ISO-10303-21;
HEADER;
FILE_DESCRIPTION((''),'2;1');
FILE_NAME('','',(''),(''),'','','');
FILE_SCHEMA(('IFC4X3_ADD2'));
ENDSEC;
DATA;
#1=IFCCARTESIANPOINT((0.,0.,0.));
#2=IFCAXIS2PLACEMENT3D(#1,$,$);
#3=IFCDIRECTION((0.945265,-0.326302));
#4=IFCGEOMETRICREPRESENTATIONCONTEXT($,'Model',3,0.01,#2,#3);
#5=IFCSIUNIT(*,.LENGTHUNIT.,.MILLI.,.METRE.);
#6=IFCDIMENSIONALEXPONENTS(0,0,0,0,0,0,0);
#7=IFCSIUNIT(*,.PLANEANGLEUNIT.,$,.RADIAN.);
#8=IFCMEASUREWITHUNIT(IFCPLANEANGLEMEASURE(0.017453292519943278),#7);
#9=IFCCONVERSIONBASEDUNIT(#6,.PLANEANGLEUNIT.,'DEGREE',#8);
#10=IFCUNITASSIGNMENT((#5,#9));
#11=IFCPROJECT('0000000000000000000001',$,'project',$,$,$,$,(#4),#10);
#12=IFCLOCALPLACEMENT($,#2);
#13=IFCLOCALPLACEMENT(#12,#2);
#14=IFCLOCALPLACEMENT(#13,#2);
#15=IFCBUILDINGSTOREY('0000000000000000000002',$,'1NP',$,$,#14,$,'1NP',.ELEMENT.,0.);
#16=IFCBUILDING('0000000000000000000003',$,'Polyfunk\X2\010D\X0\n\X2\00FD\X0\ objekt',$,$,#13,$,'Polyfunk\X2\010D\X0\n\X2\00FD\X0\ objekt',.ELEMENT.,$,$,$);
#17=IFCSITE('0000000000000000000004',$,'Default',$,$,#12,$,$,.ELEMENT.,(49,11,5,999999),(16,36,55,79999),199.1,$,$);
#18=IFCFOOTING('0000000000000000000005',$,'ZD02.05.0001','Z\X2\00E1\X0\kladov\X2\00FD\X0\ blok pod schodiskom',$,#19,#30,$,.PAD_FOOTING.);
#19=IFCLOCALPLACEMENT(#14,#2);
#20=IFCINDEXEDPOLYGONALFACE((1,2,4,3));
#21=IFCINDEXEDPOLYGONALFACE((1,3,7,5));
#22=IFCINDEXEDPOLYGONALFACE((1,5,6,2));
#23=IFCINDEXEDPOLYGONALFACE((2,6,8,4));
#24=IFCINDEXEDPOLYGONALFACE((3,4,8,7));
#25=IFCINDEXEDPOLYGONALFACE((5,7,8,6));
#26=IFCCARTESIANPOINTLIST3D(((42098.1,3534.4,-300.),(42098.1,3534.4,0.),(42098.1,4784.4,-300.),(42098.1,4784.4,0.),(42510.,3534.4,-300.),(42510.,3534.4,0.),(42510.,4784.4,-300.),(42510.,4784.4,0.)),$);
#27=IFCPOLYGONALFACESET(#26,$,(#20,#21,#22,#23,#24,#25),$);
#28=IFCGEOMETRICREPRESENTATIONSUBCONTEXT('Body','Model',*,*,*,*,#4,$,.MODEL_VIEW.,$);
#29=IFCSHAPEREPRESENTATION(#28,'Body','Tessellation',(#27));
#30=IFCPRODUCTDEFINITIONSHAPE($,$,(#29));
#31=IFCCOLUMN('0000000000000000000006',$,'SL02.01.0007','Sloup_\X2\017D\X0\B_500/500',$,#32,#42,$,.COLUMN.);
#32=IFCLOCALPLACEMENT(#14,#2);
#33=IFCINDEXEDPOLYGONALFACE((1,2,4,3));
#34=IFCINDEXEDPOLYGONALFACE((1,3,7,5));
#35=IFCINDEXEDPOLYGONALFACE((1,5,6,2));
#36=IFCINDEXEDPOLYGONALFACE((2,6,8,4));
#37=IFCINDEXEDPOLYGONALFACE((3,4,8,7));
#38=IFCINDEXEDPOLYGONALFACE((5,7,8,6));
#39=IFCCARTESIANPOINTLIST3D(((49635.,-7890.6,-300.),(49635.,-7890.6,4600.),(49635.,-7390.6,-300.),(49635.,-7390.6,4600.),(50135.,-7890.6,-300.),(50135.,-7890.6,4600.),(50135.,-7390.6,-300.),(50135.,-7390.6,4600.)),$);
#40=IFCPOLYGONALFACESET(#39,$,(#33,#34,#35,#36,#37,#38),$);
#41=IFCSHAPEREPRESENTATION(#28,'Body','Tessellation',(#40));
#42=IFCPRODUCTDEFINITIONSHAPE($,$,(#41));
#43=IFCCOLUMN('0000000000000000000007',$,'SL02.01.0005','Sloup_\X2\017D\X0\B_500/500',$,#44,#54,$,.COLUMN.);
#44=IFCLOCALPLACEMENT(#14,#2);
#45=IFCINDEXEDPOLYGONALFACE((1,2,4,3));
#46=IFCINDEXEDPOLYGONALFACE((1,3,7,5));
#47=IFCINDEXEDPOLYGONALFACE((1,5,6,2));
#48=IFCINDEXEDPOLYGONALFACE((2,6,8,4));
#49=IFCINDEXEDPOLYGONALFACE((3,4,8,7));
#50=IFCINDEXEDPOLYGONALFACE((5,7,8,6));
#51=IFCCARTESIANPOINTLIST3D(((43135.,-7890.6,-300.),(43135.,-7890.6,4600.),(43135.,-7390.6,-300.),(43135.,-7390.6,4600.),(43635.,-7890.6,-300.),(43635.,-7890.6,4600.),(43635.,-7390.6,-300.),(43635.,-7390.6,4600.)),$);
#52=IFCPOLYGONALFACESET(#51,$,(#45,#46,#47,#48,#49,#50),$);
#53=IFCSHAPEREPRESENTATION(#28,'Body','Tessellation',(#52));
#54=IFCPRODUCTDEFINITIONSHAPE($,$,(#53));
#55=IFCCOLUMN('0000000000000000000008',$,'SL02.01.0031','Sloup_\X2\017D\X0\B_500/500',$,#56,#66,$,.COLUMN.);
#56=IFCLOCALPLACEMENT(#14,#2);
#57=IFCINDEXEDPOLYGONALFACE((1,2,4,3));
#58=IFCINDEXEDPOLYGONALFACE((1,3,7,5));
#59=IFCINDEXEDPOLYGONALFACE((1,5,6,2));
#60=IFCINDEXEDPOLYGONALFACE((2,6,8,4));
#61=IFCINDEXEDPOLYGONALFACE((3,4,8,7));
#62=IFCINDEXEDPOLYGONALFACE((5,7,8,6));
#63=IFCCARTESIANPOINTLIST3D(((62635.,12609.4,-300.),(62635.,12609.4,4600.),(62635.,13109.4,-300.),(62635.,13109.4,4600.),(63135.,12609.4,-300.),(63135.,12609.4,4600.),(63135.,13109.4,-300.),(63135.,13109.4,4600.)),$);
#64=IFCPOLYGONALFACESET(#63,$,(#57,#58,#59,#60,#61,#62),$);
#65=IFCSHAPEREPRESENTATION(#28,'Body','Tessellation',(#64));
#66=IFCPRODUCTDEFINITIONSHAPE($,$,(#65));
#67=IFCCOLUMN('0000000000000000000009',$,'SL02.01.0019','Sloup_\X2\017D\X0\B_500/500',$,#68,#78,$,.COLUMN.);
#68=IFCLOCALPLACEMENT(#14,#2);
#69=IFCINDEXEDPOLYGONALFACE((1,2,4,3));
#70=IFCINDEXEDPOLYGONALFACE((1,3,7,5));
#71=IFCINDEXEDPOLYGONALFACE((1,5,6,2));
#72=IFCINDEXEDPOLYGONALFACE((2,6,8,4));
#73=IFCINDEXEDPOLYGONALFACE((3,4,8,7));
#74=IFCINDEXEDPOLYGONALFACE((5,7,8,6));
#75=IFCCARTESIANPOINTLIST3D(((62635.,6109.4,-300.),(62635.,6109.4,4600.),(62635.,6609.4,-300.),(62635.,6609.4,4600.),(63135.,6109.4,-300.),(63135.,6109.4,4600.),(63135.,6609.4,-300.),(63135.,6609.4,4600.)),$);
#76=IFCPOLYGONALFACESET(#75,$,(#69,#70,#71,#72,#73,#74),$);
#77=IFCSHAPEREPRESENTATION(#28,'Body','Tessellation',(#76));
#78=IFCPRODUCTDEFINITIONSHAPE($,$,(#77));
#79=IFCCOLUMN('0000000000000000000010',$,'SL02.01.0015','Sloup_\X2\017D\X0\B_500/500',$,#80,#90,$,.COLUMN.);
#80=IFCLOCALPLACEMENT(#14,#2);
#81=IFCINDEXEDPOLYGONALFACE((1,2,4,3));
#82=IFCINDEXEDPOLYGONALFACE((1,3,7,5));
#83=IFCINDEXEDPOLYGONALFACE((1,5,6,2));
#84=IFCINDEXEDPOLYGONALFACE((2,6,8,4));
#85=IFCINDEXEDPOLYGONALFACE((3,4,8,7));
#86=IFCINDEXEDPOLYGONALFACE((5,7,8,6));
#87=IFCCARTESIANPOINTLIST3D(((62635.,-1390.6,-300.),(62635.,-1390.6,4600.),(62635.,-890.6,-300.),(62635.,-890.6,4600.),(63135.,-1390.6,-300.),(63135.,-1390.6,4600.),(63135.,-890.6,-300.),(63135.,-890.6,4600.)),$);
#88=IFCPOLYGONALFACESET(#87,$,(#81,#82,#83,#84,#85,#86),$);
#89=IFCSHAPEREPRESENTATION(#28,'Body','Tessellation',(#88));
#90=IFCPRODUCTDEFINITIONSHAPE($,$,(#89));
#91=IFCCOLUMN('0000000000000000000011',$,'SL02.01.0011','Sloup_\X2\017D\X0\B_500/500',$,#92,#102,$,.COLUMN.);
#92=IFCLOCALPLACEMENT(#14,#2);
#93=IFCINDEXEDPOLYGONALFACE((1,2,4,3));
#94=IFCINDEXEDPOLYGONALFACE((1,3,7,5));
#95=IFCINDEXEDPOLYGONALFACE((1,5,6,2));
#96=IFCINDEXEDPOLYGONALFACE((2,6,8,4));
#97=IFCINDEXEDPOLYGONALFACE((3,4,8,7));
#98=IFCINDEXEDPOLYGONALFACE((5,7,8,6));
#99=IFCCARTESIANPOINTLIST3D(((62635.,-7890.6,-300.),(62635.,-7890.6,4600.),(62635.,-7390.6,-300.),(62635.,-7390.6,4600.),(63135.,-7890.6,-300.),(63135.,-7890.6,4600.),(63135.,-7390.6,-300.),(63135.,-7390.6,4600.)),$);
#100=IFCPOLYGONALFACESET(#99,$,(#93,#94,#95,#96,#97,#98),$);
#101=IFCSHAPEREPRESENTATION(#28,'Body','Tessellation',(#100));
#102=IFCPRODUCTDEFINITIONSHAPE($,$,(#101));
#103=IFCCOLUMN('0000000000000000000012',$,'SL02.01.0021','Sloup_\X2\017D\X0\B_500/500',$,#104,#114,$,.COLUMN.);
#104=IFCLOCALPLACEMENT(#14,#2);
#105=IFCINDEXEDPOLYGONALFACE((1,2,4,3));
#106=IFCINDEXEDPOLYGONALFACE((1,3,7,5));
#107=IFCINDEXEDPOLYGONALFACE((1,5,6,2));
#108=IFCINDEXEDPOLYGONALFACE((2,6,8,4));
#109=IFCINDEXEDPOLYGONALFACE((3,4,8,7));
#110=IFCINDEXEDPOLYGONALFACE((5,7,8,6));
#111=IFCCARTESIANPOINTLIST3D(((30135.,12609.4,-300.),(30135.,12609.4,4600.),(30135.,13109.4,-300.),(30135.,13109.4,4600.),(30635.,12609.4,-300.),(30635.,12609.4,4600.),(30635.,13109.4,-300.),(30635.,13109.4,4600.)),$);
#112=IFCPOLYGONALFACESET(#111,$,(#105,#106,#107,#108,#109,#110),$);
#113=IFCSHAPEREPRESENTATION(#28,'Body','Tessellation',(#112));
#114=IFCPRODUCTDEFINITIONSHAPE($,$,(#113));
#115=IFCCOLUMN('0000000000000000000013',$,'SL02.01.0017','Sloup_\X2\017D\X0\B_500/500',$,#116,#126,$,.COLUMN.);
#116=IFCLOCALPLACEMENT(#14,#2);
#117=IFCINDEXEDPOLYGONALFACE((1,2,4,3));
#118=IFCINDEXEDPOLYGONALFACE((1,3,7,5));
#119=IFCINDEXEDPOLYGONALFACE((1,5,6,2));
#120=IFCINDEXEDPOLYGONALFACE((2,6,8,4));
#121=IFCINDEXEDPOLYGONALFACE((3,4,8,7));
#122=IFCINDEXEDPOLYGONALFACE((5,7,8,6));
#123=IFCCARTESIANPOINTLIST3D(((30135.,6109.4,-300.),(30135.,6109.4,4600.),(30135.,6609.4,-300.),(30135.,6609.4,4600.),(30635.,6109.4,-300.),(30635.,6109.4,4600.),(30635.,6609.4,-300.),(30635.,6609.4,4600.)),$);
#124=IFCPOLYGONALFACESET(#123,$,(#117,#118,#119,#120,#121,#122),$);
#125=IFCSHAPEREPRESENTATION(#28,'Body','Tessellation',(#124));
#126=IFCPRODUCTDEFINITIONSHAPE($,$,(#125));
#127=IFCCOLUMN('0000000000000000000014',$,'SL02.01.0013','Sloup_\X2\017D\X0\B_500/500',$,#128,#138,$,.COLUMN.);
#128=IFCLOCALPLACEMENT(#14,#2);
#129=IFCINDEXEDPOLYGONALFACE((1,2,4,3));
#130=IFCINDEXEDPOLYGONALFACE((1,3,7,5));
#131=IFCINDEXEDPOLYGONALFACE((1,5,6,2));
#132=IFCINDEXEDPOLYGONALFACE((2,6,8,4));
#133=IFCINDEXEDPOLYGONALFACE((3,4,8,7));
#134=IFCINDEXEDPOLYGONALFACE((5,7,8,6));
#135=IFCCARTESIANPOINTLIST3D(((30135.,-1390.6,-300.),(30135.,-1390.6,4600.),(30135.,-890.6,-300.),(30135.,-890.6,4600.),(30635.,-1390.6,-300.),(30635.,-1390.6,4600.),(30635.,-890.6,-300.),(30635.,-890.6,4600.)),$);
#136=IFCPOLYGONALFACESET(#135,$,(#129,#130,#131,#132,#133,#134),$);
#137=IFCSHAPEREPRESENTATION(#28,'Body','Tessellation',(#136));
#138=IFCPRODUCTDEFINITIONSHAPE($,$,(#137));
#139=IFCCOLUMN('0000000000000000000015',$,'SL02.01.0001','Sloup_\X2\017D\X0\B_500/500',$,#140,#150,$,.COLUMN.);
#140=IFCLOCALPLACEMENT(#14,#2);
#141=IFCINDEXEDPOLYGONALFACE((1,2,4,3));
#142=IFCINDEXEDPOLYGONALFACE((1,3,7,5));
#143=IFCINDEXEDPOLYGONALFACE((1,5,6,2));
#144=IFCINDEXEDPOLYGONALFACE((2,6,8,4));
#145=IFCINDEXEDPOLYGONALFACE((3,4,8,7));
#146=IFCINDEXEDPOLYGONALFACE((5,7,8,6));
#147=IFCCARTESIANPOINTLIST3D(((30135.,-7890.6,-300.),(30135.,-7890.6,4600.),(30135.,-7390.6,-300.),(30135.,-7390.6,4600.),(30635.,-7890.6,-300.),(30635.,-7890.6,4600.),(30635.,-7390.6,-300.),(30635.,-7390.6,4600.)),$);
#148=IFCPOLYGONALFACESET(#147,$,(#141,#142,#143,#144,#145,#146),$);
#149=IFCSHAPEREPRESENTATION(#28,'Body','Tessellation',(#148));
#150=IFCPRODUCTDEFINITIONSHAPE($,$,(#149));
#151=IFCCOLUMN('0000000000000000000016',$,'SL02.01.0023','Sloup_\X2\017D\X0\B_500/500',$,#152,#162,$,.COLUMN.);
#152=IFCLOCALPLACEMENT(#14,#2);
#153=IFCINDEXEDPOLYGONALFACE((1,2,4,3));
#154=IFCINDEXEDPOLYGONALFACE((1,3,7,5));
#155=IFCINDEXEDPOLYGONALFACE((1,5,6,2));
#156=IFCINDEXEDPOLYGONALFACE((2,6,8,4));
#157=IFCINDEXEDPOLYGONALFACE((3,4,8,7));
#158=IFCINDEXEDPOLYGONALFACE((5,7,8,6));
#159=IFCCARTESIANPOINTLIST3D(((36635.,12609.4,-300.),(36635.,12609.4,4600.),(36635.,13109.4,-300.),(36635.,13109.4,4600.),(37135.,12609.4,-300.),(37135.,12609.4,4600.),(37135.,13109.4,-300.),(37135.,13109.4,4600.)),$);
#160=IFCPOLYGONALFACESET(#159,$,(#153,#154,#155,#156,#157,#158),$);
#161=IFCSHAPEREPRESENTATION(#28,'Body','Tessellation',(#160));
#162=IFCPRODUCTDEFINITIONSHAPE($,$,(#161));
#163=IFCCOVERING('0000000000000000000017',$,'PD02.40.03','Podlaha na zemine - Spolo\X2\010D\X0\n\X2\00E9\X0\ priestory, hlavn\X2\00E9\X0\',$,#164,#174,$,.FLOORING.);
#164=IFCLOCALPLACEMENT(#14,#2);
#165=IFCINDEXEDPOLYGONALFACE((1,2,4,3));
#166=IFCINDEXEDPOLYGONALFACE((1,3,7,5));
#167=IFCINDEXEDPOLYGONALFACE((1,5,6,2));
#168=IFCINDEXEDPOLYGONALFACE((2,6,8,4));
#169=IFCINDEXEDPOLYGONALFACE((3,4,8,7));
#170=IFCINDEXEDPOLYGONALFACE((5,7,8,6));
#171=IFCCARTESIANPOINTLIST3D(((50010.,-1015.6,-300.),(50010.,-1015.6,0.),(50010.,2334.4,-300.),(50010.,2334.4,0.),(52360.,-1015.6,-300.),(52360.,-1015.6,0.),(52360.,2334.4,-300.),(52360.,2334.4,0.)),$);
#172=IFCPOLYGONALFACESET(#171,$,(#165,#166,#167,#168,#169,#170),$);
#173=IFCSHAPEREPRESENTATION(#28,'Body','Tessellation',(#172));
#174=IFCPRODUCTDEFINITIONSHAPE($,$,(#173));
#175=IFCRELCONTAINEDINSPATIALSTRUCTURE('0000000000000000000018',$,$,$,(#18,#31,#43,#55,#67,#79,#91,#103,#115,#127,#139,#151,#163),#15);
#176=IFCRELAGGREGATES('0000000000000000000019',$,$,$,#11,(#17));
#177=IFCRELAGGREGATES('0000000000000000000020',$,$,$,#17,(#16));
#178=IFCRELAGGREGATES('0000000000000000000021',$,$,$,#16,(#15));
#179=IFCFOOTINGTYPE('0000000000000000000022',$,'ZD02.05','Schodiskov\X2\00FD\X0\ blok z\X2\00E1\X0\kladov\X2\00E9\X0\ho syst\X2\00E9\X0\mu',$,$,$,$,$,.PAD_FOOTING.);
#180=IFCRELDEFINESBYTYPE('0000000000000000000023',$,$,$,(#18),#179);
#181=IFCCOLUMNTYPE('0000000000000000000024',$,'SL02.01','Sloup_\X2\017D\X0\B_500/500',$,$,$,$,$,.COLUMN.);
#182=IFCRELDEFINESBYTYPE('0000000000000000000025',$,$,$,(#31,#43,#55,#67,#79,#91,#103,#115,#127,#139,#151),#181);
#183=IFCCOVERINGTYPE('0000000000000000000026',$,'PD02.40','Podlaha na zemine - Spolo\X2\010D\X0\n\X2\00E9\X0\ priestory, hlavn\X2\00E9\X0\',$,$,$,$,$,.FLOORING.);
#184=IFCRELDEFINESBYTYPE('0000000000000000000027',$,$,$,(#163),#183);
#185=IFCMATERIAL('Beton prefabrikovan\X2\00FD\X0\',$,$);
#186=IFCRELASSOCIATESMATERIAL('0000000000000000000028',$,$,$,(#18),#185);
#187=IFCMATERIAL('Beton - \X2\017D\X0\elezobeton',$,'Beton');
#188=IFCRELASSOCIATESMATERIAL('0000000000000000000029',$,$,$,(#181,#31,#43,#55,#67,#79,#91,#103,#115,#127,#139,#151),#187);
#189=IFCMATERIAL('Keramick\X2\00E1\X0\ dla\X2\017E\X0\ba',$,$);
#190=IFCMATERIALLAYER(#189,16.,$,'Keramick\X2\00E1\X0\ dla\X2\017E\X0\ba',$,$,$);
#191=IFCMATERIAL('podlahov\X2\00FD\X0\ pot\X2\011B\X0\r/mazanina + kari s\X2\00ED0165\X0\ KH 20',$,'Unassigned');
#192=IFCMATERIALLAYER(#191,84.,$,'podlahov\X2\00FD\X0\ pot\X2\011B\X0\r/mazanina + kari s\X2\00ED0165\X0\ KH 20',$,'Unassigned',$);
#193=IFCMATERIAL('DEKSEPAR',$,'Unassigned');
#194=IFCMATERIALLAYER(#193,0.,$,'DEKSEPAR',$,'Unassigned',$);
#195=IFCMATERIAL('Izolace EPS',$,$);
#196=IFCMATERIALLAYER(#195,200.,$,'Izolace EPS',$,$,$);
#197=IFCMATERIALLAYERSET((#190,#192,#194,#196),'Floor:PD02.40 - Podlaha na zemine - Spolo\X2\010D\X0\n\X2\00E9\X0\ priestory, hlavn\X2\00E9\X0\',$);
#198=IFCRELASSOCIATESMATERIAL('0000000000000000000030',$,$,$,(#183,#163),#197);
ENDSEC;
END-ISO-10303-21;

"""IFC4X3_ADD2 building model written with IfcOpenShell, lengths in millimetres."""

from ifc_helpers import new_model, entity, si_unit, converted_unit, direction, frame, frame_2d, origin, origin_2d_with_axis, place, context, subcontext, project, spatial, rectangle, extrude, source, transform, mapped, material, layer, layer_set, layer_usage, material_profile, profile_set, profile_usage, type_object, element, save


model = new_model("IFC4X3_ADD2")

# Units and contexts
model_context = context("Model", 3, precision=0.01, world=origin(), true_north=direction((0.945265, -0.326302)))
body_context = subcontext(model_context, "Body", "Model", "MODEL_VIEW")
ifc_project = project(units=[si_unit("LENGTHUNIT", "METRE", prefix="MILLI"), converted_unit("PLANEANGLEUNIT", "DEGREE", entity("IfcPlaneAngleMeasure", 0.017453292519943278), si_unit("PLANEANGLEUNIT", "RADIAN"), dimensions=[0, 0, 0, 0, 0, 0, 0])], contexts=[model_context])

# Site, building, storey
site_placement = place(None, origin())
site = spatial("IfcSite", under=ifc_project, at=site_placement, Name="Default", CompositionType="ELEMENT", RefLatitude=(49, 11, 5, 999999), RefLongitude=(16, 36, 55, 79999), RefElevation=199.1)
building_placement = place(site_placement, origin())
building = spatial("IfcBuilding", under=site, at=building_placement, Name="Polyfunkčný objekt", LongName="Polyfunkčný objekt", CompositionType="ELEMENT")
storey_placement = place(building_placement, origin())
storey = spatial("IfcBuildingStorey", under=building, at=storey_placement, Name="1NP", LongName="1NP", CompositionType="ELEMENT", Elevation=0.0)

# Footing
ifc_material_1 = material(Name="Beton prefabrikovaný")
footing_type = type_object("IfcFootingType", Name="ZD02.05", Description="Schodiskový blok základového systému", PredefinedType="PAD_FOOTING")
footing_placement = place(storey_placement, origin())
element("IfcFooting", 1, at=footing_placement, inside=storey, type_object=footing_type, material=ifc_material_1, Name="ZD02.05.0001", Description="Základový blok pod schodiskom", PredefinedType="PAD_FOOTING", context=body_context, shape_type="SweptSolid", body=[
    extrude(rectangle(XDim=1250.0, YDim=411.8, at=frame_2d((0.0, 0.0), x_axis=(1.0, 0.0))), frame((42304.0, 4159.4, -300.0), z_axis=(0.0, 0.0, 1.0), x_axis=(0.0, -1.0, 0.0)), (0.0, 0.0, 1.0), 300.0),
])

# Columns
ifc_material_2 = material(Name="Beton - Železobeton", Category="Beton")
ifc_material_profile = material_profile(ifc_material_2, rectangle(XDim=500.0, YDim=500.0, at=frame_2d((0.0, 0.0), x_axis=(1.0, 0.0))), Name="Sloup_ŽB_500/500")
ifc_profile_set = profile_set([ifc_material_profile], Name="Sloup_ŽB_500/500")
ifc_profile_usage = profile_usage(ifc_profile_set)
column_type = type_object("IfcColumnType", Name="SL02.01", Description="Sloup_ŽB_500/500", PredefinedType="COLUMN", material=ifc_profile_set)
shared_shape_1 = source(origin(), body_context, "Body", "SweptSolid", [
    extrude(rectangle(XDim=500.0, YDim=500.0, at=frame_2d((0.0, 0.0), x_axis=(1.0, 0.0))), frame((49885.0, -7640.6, -300.0)), (0.0, 0.0, 1.0), 4900.0),
])
column_1_placement = place(storey_placement, origin())
element("IfcColumn", 2, at=column_1_placement, inside=storey, type_object=column_type, material=ifc_profile_usage, Name="SL02.01.0007", Description="Sloup_ŽB_500/500", PredefinedType="COLUMN", context=body_context, shape_type="MappedRepresentation", body=[
    mapped(shared_shape_1, transform((0.0, 0.0, 0.0), scale=1.0)),
])
shared_shape_2 = source(origin(), body_context, "Body", "SweptSolid", [
    extrude(rectangle(XDim=500.0, YDim=500.0, at=origin_2d_with_axis()), frame((43385.0, -7640.6, -300.0)), (0.0, 0.0, 1.0), 4900.0),
])
column_2_placement = place(storey_placement, origin())
element("IfcColumn", 3, at=column_2_placement, inside=storey, type_object=column_type, material=ifc_profile_usage, Name="SL02.01.0005", Description="Sloup_ŽB_500/500", PredefinedType="COLUMN", context=body_context, shape_type="MappedRepresentation", body=[
    mapped(shared_shape_2, transform((0.0, 0.0, 0.0), scale=1.0)),
])
shared_shape_3 = source(origin(), body_context, "Body", "SweptSolid", [
    extrude(rectangle(XDim=500.0, YDim=500.0, at=origin_2d_with_axis()), frame((62885.0, 12859.4, -300.0), z_axis=(0.0, 0.0, 1.0), x_axis=(-1.0, 0.0, 0.0)), (0.0, 0.0, 1.0), 4900.0),
])
column_3_placement = place(storey_placement, origin())
element("IfcColumn", 4, at=column_3_placement, inside=storey, type_object=column_type, material=ifc_profile_usage, Name="SL02.01.0031", Description="Sloup_ŽB_500/500", PredefinedType="COLUMN", context=body_context, shape_type="MappedRepresentation", body=[
    mapped(shared_shape_3, transform((0.0, 0.0, 0.0), scale=1.0)),
])
shared_shape_4 = source(origin(), body_context, "Body", "SweptSolid", [
    extrude(rectangle(XDim=500.0, YDim=500.0, at=origin_2d_with_axis()), frame((62885.0, 6359.4, -300.0), z_axis=(0.0, 0.0, 1.0), x_axis=(0.0, -1.0, 0.0)), (0.0, 0.0, 1.0), 4900.0),
])
column_4_placement = place(storey_placement, origin())
element("IfcColumn", 5, at=column_4_placement, inside=storey, type_object=column_type, material=ifc_profile_usage, Name="SL02.01.0019", Description="Sloup_ŽB_500/500", PredefinedType="COLUMN", context=body_context, shape_type="MappedRepresentation", body=[
    mapped(shared_shape_4, transform((0.0, 0.0, 0.0), scale=1.0)),
])
shared_shape_5 = source(origin(), body_context, "Body", "SweptSolid", [
    extrude(rectangle(XDim=500.0, YDim=500.0, at=origin_2d_with_axis()), frame((62885.0, -1140.6, -300.0), z_axis=(0.0, 0.0, 1.0), x_axis=(0.0, -1.0, 0.0)), (0.0, 0.0, 1.0), 4900.0),
])
column_5_placement = place(storey_placement, origin())
element("IfcColumn", 6, at=column_5_placement, inside=storey, type_object=column_type, material=ifc_profile_usage, Name="SL02.01.0015", Description="Sloup_ŽB_500/500", PredefinedType="COLUMN", context=body_context, shape_type="MappedRepresentation", body=[
    mapped(shared_shape_5, transform((0.0, 0.0, 0.0), scale=1.0)),
])
shared_shape_6 = source(origin(), body_context, "Body", "SweptSolid", [
    extrude(rectangle(XDim=500.0, YDim=500.0, at=origin_2d_with_axis()), frame((62885.0, -7640.6, -300.0), z_axis=(0.0, 0.0, 1.0), x_axis=(-1.0, 0.0, 0.0)), (0.0, 0.0, 1.0), 4900.0),
])
column_6_placement = place(storey_placement, origin())
element("IfcColumn", 7, at=column_6_placement, inside=storey, type_object=column_type, material=ifc_profile_usage, Name="SL02.01.0011", Description="Sloup_ŽB_500/500", PredefinedType="COLUMN", context=body_context, shape_type="MappedRepresentation", body=[
    mapped(shared_shape_6, transform((0.0, 0.0, 0.0), scale=1.0)),
])
shared_shape_7 = source(origin(), body_context, "Body", "SweptSolid", [
    extrude(rectangle(XDim=500.0, YDim=500.0, at=origin_2d_with_axis()), frame((30385.0, 12859.4, -300.0), z_axis=(0.0, 0.0, 1.0), x_axis=(-1.0, 0.0, 0.0)), (0.0, 0.0, 1.0), 4900.0),
])
column_7_placement = place(storey_placement, origin())
element("IfcColumn", 8, at=column_7_placement, inside=storey, type_object=column_type, material=ifc_profile_usage, Name="SL02.01.0021", Description="Sloup_ŽB_500/500", PredefinedType="COLUMN", context=body_context, shape_type="MappedRepresentation", body=[
    mapped(shared_shape_7, transform((0.0, 0.0, 0.0), scale=1.0)),
])
shared_shape_8 = source(origin(), body_context, "Body", "SweptSolid", [
    extrude(rectangle(XDim=500.0, YDim=500.0, at=frame_2d((0.0, 0.0), x_axis=(1.0, 0.0))), frame((30385.0, 6359.4, -300.0), z_axis=(0.0, 0.0, 1.0), x_axis=(0.0, -1.0, 0.0)), (0.0, 0.0, 1.0), 4900.0),
])
column_8_placement = place(storey_placement, origin())
element("IfcColumn", 9, at=column_8_placement, inside=storey, type_object=column_type, material=ifc_profile_usage, Name="SL02.01.0017", Description="Sloup_ŽB_500/500", PredefinedType="COLUMN", context=body_context, shape_type="MappedRepresentation", body=[
    mapped(shared_shape_8, transform((0.0, 0.0, 0.0), scale=1.0)),
])
shared_shape_9 = source(origin(), body_context, "Body", "SweptSolid", [
    extrude(rectangle(XDim=500.0, YDim=500.0, at=origin_2d_with_axis()), frame((30385.0, -1140.6, -300.0), z_axis=(0.0, 0.0, 1.0), x_axis=(0.0, -1.0, 0.0)), (0.0, 0.0, 1.0), 4900.0),
])
column_9_placement = place(storey_placement, origin())
element("IfcColumn", 10, at=column_9_placement, inside=storey, type_object=column_type, material=ifc_profile_usage, Name="SL02.01.0013", Description="Sloup_ŽB_500/500", PredefinedType="COLUMN", context=body_context, shape_type="MappedRepresentation", body=[
    mapped(shared_shape_9, transform((0.0, 0.0, 0.0), scale=1.0)),
])
shared_shape_10 = source(origin(), body_context, "Body", "SweptSolid", [
    extrude(rectangle(XDim=500.0, YDim=500.0, at=frame_2d((0.0, 0.0), x_axis=(1.0, 0.0))), frame((30385.0, -7640.6, -300.0), z_axis=(0.0, 0.0, 1.0), x_axis=(-1.0, 0.0, 0.0)), (0.0, 0.0, 1.0), 4900.0),
])
column_10_placement = place(storey_placement, origin())
element("IfcColumn", 11, at=column_10_placement, inside=storey, type_object=column_type, material=ifc_profile_usage, Name="SL02.01.0001", Description="Sloup_ŽB_500/500", PredefinedType="COLUMN", context=body_context, shape_type="MappedRepresentation", body=[
    mapped(shared_shape_10, transform((0.0, 0.0, 0.0), scale=1.0)),
])
shared_shape_11 = source(origin(), body_context, "Body", "SweptSolid", [
    extrude(rectangle(XDim=500.0, YDim=500.0, at=frame_2d((-83.3, 0.0), x_axis=(1.0, 0.0))), frame((36885.0, 12776.1, -300.0), z_axis=(0.0, 0.0, 1.0), x_axis=(0.0, -1.0, 0.0)), (0.0, 0.0, 1.0), 4900.0),
])
column_11_placement = place(storey_placement, origin())
element("IfcColumn", 12, at=column_11_placement, inside=storey, type_object=column_type, material=ifc_profile_usage, Name="SL02.01.0023", Description="Sloup_ŽB_500/500", PredefinedType="COLUMN", context=body_context, shape_type="MappedRepresentation", body=[
    mapped(shared_shape_11, transform((0.0, 0.0, 0.0), scale=1.0)),
])

# Shared definitions
ifc_material_3 = material(Name="podlahový potěr/mazanina + kari síť KH 20", Category="Unassigned")
ifc_material_4 = material(Name="DEKSEPAR", Category="Unassigned")
ifc_material_5 = material(Name="Izolace EPS")
ifc_material_6 = material(Name="Keramická dlažba")

# Covering
ifc_layer_1 = layer(ifc_material_6, 16.0, Name="Keramická dlažba")
ifc_layer_2 = layer(ifc_material_3, 84.0, Name="podlahový potěr/mazanina + kari síť KH 20", Category="Unassigned")
ifc_layer_3 = layer(ifc_material_4, 0.0, Name="DEKSEPAR", Category="Unassigned")
ifc_layer_4 = layer(ifc_material_5, 200.0, Name="Izolace EPS")
ifc_layer_set_1 = layer_set([ifc_layer_1, ifc_layer_2, ifc_layer_3, ifc_layer_4], Name="Floor:PD02.40 - Podlaha na zemine - Spoločné priestory, hlavné")
covering_type_1 = type_object("IfcCoveringType", Name="PD02.40", Description="Podlaha na zemine - Spoločné priestory, hlavné", PredefinedType="FLOORING", material=ifc_layer_set_1)
ifc_layer_usage_1 = layer_usage(ifc_layer_set_1, "AXIS3", "POSITIVE", 0.0)
covering_1_placement = place(storey_placement, origin())
element("IfcCovering", 13, at=covering_1_placement, inside=storey, type_object=covering_type_1, material=ifc_layer_usage_1, Name="PD02.40.03", Description="Podlaha na zemine - Spoločné priestory, hlavné", PredefinedType="FLOORING", context=body_context, shape_type="SweptSolid", body=[
    extrude(rectangle(XDim=3350.0, YDim=2350.0, at=frame_2d((0.0, 0.0), x_axis=(1.0, 0.0))), frame((51185.0, 659.4, 0.0), z_axis=(0.0, 0.0, -1.0), x_axis=(0.0, 1.0, 0.0)), (0.0, 0.0, 1.0), 300.0),
])

save(model, "model.ifc")
